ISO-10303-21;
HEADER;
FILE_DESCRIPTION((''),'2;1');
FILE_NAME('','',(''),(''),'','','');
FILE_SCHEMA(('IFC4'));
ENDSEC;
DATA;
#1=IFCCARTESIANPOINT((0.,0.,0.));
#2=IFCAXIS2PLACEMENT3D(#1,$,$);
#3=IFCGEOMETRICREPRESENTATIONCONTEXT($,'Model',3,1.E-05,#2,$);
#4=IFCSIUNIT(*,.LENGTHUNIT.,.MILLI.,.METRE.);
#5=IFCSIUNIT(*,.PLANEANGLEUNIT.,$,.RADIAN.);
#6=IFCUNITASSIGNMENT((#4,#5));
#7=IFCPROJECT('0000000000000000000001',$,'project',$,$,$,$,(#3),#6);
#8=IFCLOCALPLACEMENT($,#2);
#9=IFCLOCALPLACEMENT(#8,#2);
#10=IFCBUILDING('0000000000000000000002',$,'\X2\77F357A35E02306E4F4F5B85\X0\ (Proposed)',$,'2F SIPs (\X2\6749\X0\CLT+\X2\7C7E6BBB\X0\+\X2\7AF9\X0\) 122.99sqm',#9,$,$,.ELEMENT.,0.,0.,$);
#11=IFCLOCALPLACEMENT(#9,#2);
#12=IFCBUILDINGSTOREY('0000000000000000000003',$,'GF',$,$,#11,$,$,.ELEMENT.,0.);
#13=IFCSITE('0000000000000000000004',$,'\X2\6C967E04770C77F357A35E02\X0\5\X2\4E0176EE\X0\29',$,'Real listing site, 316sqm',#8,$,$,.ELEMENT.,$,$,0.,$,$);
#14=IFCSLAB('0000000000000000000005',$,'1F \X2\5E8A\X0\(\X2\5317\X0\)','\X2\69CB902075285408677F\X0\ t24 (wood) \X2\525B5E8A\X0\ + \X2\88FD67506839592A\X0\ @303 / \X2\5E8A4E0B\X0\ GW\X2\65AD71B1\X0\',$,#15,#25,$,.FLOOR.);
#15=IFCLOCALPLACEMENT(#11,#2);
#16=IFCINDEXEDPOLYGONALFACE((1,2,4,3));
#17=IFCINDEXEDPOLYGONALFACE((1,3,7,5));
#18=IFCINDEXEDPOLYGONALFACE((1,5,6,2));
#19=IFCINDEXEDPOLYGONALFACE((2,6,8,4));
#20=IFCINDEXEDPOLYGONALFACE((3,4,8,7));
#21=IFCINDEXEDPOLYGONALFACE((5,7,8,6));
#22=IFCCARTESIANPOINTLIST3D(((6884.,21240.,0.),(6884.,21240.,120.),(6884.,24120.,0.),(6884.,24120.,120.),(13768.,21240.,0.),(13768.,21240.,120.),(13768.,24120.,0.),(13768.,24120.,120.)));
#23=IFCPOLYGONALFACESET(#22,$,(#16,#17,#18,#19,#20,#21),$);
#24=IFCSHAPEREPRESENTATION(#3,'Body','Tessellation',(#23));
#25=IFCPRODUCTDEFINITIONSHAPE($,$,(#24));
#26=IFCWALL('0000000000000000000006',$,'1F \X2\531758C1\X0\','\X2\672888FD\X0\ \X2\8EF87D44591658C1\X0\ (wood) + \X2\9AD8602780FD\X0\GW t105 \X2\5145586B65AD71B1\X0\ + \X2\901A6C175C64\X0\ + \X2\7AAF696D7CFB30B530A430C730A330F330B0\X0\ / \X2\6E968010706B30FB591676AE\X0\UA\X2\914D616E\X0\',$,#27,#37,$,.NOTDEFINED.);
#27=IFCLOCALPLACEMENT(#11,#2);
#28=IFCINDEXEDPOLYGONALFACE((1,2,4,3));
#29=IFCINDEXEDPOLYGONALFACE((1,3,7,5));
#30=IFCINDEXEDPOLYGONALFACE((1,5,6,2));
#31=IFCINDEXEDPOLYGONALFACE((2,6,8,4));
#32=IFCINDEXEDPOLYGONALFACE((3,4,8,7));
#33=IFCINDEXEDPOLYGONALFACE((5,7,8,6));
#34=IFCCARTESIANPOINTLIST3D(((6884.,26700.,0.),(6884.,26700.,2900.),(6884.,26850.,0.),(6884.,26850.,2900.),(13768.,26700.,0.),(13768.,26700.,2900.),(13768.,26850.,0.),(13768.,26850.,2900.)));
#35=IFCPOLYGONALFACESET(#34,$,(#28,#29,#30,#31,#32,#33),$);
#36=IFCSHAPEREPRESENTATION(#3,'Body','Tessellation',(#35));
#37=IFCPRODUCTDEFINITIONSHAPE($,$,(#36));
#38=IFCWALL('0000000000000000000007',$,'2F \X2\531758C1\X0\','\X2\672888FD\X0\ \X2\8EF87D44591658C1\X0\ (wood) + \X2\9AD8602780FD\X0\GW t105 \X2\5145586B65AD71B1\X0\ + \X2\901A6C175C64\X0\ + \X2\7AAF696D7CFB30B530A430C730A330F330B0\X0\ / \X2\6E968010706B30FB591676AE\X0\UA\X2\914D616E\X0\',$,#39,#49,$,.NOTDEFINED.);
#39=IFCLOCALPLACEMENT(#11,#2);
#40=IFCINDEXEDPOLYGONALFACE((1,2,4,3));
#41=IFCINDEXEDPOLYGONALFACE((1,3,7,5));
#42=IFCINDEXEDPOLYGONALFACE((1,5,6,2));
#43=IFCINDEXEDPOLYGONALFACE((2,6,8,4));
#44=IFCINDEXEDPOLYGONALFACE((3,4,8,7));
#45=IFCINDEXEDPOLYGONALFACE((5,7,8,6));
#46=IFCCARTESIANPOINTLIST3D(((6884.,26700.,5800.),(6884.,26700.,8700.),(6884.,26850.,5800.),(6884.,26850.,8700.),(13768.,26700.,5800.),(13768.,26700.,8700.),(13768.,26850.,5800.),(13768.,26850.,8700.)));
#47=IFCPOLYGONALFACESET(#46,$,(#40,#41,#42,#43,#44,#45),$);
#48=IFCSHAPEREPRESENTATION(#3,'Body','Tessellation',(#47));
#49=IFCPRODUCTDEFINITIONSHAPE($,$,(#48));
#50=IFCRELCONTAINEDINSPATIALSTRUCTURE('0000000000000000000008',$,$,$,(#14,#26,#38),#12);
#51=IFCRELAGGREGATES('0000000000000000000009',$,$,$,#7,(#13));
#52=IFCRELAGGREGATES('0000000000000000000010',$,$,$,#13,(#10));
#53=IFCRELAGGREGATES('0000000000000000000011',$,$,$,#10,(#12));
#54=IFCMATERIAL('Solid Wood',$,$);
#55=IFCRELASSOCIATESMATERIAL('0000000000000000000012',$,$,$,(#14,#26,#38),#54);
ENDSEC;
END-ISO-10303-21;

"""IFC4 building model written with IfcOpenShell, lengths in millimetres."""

from ifc_helpers import new_model, si_unit, frame, frame_2d, origin, place, context, project, spatial, rectangle, extrude, material, element, save


model = new_model("IFC4")

# Units and contexts
model_context = context("Model", 3, precision=1e-05, world=origin())
ifc_project = project(units=[si_unit("LENGTHUNIT", "METRE", prefix="MILLI"), si_unit("PLANEANGLEUNIT", "RADIAN")], contexts=[model_context])

# Site, building, storey
site_placement = place(None, origin())
site = spatial("IfcSite", under=ifc_project, at=site_placement, Name="沖縄県石垣市5丁目29", ObjectType="Real listing site, 316sqm", CompositionType="ELEMENT", RefElevation=0.0)
building_placement = place(site_placement, origin())
building = spatial("IfcBuilding", under=site, at=building_placement, Name="石垣市の住宅 (Proposed)", ObjectType="2F SIPs (杉CLT+籾殻+竹) 122.99sqm", CompositionType="ELEMENT", ElevationOfRefHeight=0.0, ElevationOfTerrain=0.0)
storey_placement = place(building_placement, origin())
storey = spatial("IfcBuildingStorey", under=building, at=storey_placement, Name="GF", CompositionType="ELEMENT", Elevation=0.0)

# Slab
ifc_material_1 = material(Name="Solid Wood")
slab_1_placement = place(storey_placement, frame((3442.0, 10620.0, 0.0)))
element("IfcSlab", 1, at=slab_1_placement, inside=storey, material=ifc_material_1, Name="1F 床(北)", Description="構造用合板 t24 (wood) 剛床 + 製材根太 @303 / 床下 GW断熱", PredefinedType="FLOOR", context=model_context, shape_type="SweptSolid", body=[
    extrude(rectangle(XDim=6884.0, YDim=2880.0, at=frame_2d((3442.0, 1440.0))), frame((3442.0, 10620.0, 0.0)), (0.0, 0.0, 1.0), 120.0),
])

# Wall
wall_1_placement = place(storey_placement, frame((3442.0, 13350.0, 0.0)))
element("IfcWall", 2, at=wall_1_placement, inside=storey, material=ifc_material_1, Name="1F 北壁", Description="木製 軸組外壁 (wood) + 高性能GW t105 充填断熱 + 通気層 + 窯業系サイディング / 準耐火・外皮UA配慮", PredefinedType="NOTDEFINED", context=model_context, shape_type="SweptSolid", body=[
    extrude(rectangle(XDim=6884.0, YDim=150.0, at=frame_2d((3442.0, 75.0))), frame((3442.0, 13350.0, 0.0)), (0.0, 0.0, 1.0), 2900.0),
])

# Wall
wall_2_placement = place(storey_placement, frame((3442.0, 13350.0, 2900.0)))
element("IfcWall", 3, at=wall_2_placement, inside=storey, material=ifc_material_1, Name="2F 北壁", Description="木製 軸組外壁 (wood) + 高性能GW t105 充填断熱 + 通気層 + 窯業系サイディング / 準耐火・外皮UA配慮", PredefinedType="NOTDEFINED", context=model_context, shape_type="SweptSolid", body=[
    extrude(rectangle(XDim=6884.0, YDim=150.0, at=frame_2d((3442.0, 75.0))), frame((3442.0, 13350.0, 2900.0)), (0.0, 0.0, 1.0), 2900.0),
])

save(model, "model.ifc")
